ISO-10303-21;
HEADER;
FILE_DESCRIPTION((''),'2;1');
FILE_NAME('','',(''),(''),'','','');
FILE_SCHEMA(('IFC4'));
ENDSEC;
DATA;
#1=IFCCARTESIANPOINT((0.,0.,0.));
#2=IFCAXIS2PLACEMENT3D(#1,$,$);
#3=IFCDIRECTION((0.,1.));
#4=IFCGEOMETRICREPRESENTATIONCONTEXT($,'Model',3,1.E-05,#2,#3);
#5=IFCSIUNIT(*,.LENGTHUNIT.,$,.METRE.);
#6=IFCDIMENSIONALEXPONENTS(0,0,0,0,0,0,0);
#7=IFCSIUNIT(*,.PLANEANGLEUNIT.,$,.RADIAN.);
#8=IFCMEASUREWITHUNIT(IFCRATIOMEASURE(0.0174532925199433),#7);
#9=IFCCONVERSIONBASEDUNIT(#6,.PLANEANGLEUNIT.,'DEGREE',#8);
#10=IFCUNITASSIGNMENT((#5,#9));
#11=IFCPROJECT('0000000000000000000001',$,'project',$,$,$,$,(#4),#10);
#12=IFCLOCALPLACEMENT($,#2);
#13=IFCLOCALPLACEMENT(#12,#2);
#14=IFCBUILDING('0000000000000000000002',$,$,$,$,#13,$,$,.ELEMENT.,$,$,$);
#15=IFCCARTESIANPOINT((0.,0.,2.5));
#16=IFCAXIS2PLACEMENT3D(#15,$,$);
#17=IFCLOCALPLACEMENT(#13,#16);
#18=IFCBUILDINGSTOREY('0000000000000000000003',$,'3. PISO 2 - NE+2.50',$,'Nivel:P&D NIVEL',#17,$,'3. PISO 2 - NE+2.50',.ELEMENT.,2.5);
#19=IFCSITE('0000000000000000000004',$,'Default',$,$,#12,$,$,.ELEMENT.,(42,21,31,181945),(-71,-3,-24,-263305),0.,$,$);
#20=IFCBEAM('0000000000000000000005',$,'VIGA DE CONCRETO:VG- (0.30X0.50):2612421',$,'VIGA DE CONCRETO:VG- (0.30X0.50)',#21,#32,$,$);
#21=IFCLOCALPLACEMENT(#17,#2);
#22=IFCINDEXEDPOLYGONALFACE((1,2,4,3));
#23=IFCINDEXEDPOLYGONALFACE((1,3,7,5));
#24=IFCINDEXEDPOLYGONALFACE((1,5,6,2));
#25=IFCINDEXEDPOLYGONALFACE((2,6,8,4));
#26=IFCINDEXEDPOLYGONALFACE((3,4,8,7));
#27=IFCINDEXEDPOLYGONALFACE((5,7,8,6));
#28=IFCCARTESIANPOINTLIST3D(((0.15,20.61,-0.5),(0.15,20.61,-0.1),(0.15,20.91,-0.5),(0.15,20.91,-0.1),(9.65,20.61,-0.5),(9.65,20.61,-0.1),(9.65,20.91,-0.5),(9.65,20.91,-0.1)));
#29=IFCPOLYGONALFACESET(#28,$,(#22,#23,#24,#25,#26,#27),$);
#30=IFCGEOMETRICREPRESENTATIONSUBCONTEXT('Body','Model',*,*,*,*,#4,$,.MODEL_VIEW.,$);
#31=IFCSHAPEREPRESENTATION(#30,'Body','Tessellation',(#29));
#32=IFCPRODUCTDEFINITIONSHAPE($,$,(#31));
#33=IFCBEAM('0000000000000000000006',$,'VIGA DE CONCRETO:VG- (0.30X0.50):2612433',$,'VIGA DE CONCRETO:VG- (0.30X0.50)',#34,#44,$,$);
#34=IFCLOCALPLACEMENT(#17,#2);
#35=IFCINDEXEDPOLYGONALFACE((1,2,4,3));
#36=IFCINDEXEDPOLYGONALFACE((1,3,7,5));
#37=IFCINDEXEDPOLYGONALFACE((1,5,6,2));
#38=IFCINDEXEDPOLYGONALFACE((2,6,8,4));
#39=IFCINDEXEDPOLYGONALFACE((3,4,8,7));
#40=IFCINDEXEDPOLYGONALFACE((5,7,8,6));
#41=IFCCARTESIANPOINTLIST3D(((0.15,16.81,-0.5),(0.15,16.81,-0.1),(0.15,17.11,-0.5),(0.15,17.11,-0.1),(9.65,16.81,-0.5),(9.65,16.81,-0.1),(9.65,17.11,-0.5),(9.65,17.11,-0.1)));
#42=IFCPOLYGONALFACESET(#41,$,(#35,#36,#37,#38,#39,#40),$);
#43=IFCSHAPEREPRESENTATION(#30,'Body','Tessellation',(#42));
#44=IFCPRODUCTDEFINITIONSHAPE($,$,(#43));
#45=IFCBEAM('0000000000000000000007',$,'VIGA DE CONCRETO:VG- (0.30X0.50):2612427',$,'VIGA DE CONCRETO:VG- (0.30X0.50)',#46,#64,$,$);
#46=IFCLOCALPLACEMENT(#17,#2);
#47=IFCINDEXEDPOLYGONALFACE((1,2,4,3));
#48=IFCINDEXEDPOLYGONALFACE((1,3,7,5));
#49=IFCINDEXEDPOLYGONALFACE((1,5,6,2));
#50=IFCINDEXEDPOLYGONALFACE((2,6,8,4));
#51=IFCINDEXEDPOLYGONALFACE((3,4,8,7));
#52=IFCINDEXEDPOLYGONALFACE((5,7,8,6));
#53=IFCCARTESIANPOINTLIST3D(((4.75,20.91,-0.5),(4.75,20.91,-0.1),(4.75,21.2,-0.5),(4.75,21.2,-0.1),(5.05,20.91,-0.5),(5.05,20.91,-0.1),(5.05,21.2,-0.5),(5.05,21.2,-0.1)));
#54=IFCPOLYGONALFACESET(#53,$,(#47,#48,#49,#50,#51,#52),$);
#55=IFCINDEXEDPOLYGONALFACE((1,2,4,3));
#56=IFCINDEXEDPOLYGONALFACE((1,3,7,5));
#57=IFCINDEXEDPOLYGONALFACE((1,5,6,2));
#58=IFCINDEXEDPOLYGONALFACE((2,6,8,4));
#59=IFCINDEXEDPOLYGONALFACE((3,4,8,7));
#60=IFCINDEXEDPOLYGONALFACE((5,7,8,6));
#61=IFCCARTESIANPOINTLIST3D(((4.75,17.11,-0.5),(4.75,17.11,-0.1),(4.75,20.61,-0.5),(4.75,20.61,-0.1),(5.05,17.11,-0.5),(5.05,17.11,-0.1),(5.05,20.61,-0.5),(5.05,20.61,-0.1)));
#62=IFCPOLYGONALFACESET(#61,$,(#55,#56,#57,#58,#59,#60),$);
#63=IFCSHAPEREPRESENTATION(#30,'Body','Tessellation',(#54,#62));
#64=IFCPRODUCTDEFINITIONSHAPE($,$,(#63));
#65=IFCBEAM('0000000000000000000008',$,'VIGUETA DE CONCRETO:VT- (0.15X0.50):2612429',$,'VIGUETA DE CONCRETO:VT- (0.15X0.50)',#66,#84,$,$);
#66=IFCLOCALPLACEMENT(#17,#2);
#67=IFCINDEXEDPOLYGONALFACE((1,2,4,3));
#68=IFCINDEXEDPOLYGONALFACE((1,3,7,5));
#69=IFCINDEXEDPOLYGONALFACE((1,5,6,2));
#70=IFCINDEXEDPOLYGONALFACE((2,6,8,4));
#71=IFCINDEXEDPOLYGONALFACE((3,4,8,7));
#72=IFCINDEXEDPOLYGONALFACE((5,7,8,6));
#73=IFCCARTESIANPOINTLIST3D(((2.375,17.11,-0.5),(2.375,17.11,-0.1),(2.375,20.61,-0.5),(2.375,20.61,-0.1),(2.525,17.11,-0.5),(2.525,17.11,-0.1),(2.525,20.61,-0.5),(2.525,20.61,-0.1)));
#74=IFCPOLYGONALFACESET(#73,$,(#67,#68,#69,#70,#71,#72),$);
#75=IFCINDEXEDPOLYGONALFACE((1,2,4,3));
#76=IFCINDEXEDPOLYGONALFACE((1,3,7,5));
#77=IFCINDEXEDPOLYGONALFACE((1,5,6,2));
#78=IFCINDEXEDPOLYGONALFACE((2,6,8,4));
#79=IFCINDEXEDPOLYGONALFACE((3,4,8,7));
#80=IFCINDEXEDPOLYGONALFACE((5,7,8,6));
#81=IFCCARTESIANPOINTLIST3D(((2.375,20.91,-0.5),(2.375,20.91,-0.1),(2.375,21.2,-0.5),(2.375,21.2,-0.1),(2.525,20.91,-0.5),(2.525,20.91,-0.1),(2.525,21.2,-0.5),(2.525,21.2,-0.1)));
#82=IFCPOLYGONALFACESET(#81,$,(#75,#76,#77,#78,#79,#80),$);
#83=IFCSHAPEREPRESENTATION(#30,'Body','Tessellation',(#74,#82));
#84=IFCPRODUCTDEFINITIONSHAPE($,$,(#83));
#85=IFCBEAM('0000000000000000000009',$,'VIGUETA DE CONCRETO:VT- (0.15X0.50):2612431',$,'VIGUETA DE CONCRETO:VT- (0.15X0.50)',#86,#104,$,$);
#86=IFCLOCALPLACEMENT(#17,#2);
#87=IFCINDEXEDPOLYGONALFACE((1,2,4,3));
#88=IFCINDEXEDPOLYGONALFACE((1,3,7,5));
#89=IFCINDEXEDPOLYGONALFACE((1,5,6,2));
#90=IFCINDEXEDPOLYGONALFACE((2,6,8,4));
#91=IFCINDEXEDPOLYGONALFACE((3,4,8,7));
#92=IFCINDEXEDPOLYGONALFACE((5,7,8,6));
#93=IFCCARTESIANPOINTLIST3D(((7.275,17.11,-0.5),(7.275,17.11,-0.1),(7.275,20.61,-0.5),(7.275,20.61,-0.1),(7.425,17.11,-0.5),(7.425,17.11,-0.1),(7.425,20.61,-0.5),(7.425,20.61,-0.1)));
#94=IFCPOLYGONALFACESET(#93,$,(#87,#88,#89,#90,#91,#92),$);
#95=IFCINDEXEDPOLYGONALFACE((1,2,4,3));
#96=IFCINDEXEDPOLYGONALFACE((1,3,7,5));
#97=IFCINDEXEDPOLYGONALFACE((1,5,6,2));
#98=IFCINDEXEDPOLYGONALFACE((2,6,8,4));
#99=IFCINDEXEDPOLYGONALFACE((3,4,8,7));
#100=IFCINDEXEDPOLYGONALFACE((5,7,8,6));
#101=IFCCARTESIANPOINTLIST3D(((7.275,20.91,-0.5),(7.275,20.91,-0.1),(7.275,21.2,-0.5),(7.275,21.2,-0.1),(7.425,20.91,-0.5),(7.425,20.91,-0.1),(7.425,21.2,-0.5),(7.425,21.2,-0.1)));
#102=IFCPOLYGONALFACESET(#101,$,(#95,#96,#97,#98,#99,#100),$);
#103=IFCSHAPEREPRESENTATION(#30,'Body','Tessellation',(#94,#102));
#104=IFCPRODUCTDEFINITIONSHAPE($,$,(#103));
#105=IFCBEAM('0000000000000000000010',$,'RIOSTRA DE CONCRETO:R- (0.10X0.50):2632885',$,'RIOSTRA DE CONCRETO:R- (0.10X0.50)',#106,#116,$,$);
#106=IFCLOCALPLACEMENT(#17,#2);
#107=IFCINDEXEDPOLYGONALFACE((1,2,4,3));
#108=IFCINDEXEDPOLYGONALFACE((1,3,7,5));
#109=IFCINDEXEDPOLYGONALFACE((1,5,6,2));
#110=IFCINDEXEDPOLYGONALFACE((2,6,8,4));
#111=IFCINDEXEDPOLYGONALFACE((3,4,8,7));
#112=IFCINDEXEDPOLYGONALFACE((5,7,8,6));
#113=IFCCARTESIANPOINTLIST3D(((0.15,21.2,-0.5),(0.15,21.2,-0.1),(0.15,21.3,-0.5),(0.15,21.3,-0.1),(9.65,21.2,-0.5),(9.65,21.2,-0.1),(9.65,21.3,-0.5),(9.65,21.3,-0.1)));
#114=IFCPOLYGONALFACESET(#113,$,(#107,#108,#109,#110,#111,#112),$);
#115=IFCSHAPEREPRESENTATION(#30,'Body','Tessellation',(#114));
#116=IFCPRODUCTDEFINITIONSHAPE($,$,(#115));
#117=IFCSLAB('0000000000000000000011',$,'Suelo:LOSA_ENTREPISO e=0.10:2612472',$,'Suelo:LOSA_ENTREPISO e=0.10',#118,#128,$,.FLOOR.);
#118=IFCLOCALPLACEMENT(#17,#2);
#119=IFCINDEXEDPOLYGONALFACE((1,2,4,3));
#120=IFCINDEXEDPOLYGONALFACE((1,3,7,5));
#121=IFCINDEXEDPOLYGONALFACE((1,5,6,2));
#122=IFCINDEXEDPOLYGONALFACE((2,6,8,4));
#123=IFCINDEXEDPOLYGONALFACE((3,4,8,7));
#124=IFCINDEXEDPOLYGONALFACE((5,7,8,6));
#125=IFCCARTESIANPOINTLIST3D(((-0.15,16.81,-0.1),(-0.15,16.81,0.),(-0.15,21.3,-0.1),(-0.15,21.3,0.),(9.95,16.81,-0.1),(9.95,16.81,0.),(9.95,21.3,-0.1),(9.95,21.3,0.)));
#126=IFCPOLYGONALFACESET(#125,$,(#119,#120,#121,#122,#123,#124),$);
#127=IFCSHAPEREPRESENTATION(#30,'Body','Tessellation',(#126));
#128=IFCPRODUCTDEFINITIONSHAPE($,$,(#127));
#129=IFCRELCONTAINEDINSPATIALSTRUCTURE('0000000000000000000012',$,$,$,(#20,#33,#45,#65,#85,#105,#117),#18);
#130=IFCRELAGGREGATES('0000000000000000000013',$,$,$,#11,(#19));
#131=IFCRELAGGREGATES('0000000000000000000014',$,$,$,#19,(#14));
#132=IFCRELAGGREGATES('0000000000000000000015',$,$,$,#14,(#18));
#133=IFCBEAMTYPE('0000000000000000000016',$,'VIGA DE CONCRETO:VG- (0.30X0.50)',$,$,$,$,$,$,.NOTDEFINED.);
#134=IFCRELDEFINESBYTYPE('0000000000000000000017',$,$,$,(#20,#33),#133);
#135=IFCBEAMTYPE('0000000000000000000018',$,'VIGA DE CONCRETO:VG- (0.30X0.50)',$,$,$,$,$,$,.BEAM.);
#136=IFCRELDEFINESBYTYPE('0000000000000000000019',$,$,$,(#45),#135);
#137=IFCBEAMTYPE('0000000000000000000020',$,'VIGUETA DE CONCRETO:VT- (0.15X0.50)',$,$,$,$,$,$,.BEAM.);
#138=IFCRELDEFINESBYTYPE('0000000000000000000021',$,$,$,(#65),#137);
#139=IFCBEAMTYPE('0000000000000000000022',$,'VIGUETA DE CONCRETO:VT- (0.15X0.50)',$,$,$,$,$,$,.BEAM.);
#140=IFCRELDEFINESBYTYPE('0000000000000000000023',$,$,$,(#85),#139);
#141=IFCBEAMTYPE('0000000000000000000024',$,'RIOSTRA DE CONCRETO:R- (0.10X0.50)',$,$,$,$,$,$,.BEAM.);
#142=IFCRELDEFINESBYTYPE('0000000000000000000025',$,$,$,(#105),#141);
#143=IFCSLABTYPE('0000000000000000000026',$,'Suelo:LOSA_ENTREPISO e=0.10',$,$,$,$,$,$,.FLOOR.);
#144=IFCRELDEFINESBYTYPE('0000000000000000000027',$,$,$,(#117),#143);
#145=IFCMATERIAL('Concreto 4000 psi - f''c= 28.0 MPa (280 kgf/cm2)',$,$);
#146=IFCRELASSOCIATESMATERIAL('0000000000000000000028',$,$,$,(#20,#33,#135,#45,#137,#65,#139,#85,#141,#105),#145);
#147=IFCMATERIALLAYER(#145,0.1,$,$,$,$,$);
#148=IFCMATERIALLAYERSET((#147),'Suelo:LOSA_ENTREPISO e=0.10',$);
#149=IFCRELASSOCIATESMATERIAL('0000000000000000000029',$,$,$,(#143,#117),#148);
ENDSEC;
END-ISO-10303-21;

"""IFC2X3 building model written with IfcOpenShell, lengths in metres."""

from ifc_helpers import new_model, entity, si_unit, converted_unit, direction, frame, frame_2d, origin, origin_2d_with_axis, place, context, subcontext, project, spatial, rectangle, extrude, source, transform, mapped, material, layer, layer_set, layer_usage, type_object, type_shapes, element, save


model = new_model("IFC2X3")

# Units and contexts
model_context = context("Model", 3, precision=1e-05, world=origin(), true_north=direction((0.0, 1.0)))
body_context = subcontext(model_context, "Body", "Model", "MODEL_VIEW")
ifc_project = project(units=[si_unit("LENGTHUNIT", "METRE"), converted_unit("PLANEANGLEUNIT", "DEGREE", entity("IfcRatioMeasure", 0.0174532925199433), si_unit("PLANEANGLEUNIT", "RADIAN"), dimensions=[0, 0, 0, 0, 0, 0, 0])], contexts=[model_context])

# Site, building, storey
site_placement = place(None, origin())
site = spatial("IfcSite", under=ifc_project, at=site_placement, Name="Default", CompositionType="ELEMENT", RefLatitude=(42, 21, 31, 181945), RefLongitude=(-71, -3, -24, -263305), RefElevation=0.0)
building_placement = place(site_placement, origin())
building = spatial("IfcBuilding", under=site, at=building_placement, CompositionType="ELEMENT")
storey_placement = place(building_placement, frame((0.0, 0.0, 2.5)))
storey = spatial("IfcBuildingStorey", under=building, at=storey_placement, Name="3. PISO 2 - NE+2.50", ObjectType="Nivel:P&D NIVEL", LongName="3. PISO 2 - NE+2.50", CompositionType="ELEMENT", Elevation=2.5)

# Beams
ifc_material = material(Name="Concreto 4000 psi - f'c= 28.0 MPa (280 kgf/cm2)")
beam_type_1 = type_object("IfcBeamType", Name="VIGA DE CONCRETO:VG- (0.30X0.50)", PredefinedType="NOTDEFINED")
beam_1_placement = place(storey_placement, frame((9.8, 20.76, 0.0), z_axis=(0.0, 0.0, 1.0), x_axis=(-1.0, 0.0, 0.0)))
element("IfcBeam", 1, at=beam_1_placement, inside=storey, type_object=beam_type_1, material=ifc_material, Name="VIGA DE CONCRETO:VG- (0.30X0.50):2612421", ObjectType="VIGA DE CONCRETO:VG- (0.30X0.50)", context=body_context, shape_type="SweptSolid", body=[
    extrude(rectangle(XDim=0.4, YDim=0.3, at=frame_2d((0.0, 0.0), x_axis=(1.0, 0.0))), frame((0.15, 0.0, -0.3), z_axis=(1.0, 0.0, 0.0), x_axis=(0.0, 0.0, -1.0)), (0.0, 0.0, 1.0), 9.5),
])
beam_2_placement = place(storey_placement, frame((0.0, 16.96, 0.0)))
element("IfcBeam", 2, at=beam_2_placement, inside=storey, type_object=beam_type_1, material=ifc_material, Name="VIGA DE CONCRETO:VG- (0.30X0.50):2612433", ObjectType="VIGA DE CONCRETO:VG- (0.30X0.50)", context=body_context, shape_type="SweptSolid", body=[
    extrude(rectangle(XDim=0.4, YDim=0.3, at=frame_2d((0.0, 0.0), x_axis=(1.0, 0.0))), frame((0.15, 0.0, -0.3), z_axis=(1.0, 0.0, 0.0), x_axis=(0.0, 0.0, -1.0)), (0.0, 0.0, 1.0), 9.5),
])
beam_type_2 = type_object("IfcBeamType", Name="VIGA DE CONCRETO:VG- (0.30X0.50)", PredefinedType="BEAM", material=ifc_material)
shared_shape_1 = source(origin(), body_context, "Body", "SweptSolid", [
    extrude(rectangle(XDim=0.4, YDim=0.3, at=frame_2d((0.0, 0.0), x_axis=(0.0, 1.0))), frame((4.9, 21.2, 2.2), z_axis=(0.0, -1.0, 0.0), x_axis=(-1.0, 0.0, 0.0)), (0.0, 0.0, 1.0), 0.29),
    extrude(rectangle(XDim=0.4, YDim=0.3, at=frame_2d((0.0, 0.0), x_axis=(0.0, 1.0))), frame((4.9, 20.61, 2.2), z_axis=(0.0, -1.0, 0.0), x_axis=(-1.0, 0.0, 0.0)), (0.0, 0.0, 1.0), 3.5),
])
type_shapes(beam_type_2, [shared_shape_1])
beam_3_placement = place(storey_placement, frame((0.0, 0.0, -2.5)))
element("IfcBeam", 3, at=beam_3_placement, inside=storey, type_object=beam_type_2, material=ifc_material, Name="VIGA DE CONCRETO:VG- (0.30X0.50):2612427", ObjectType="VIGA DE CONCRETO:VG- (0.30X0.50)", context=body_context, shape_type="MappedRepresentation", body=[
    mapped(shared_shape_1, transform((0.0, 0.0, 0.0), scale=1.0)),
])
beam_type_3 = type_object("IfcBeamType", Name="VIGUETA DE CONCRETO:VT- (0.15X0.50)", PredefinedType="BEAM", material=ifc_material)
shared_shape_2 = source(origin(), body_context, "Body", "SweptSolid", [
    extrude(rectangle(XDim=0.4, YDim=0.15, at=frame_2d((0.0, 0.0), x_axis=(0.0, 1.0))), frame((2.45, 20.61, 2.2), z_axis=(0.0, -1.0, 0.0), x_axis=(-1.0, 0.0, 0.0)), (0.0, 0.0, 1.0), 3.5),
    extrude(rectangle(XDim=0.4, YDim=0.15, at=frame_2d((0.0, 0.0), x_axis=(0.0, 1.0))), frame((2.45, 21.2, 2.2), z_axis=(0.0, -1.0, 0.0), x_axis=(-1.0, 0.0, 0.0)), (0.0, 0.0, 1.0), 0.29),
])
type_shapes(beam_type_3, [shared_shape_2])
beam_4_placement = place(storey_placement, frame((0.0, 0.0, -2.5)))
element("IfcBeam", 4, at=beam_4_placement, inside=storey, type_object=beam_type_3, material=ifc_material, Name="VIGUETA DE CONCRETO:VT- (0.15X0.50):2612429", ObjectType="VIGUETA DE CONCRETO:VT- (0.15X0.50)", context=body_context, shape_type="MappedRepresentation", body=[
    mapped(shared_shape_2, transform((0.0, 0.0, 0.0), scale=1.0)),
])
beam_type_4 = type_object("IfcBeamType", Name="VIGUETA DE CONCRETO:VT- (0.15X0.50)", PredefinedType="BEAM", material=ifc_material)
shared_shape_3 = source(origin(), body_context, "Body", "SweptSolid", [
    extrude(rectangle(XDim=0.4, YDim=0.15, at=frame_2d((0.0, 0.0), x_axis=(0.0, 1.0))), frame((7.35, 20.61, 2.2), z_axis=(0.0, -1.0, 0.0), x_axis=(-1.0, 0.0, 0.0)), (0.0, 0.0, 1.0), 3.5),
    extrude(rectangle(XDim=0.4, YDim=0.15, at=frame_2d((0.0, 0.0), x_axis=(0.0, 1.0))), frame((7.35, 21.2, 2.2), z_axis=(0.0, -1.0, 0.0), x_axis=(-1.0, 0.0, 0.0)), (0.0, 0.0, 1.0), 0.29),
])
type_shapes(beam_type_4, [shared_shape_3])
beam_5_placement = place(storey_placement, frame((0.0, 0.0, -2.5)))
element("IfcBeam", 5, at=beam_5_placement, inside=storey, type_object=beam_type_4, material=ifc_material, Name="VIGUETA DE CONCRETO:VT- (0.15X0.50):2612431", ObjectType="VIGUETA DE CONCRETO:VT- (0.15X0.50)", context=body_context, shape_type="MappedRepresentation", body=[
    mapped(shared_shape_3, transform((0.0, 0.0, 0.0), scale=1.0)),
])
beam_type_5 = type_object("IfcBeamType", Name="RIOSTRA DE CONCRETO:R- (0.10X0.50)", PredefinedType="BEAM", material=ifc_material)
beam_6_placement = place(storey_placement, frame((0.0, 21.25, 0.0)))
element("IfcBeam", 6, at=beam_6_placement, inside=storey, type_object=beam_type_5, material=ifc_material, Name="RIOSTRA DE CONCRETO:R- (0.10X0.50):2632885", ObjectType="RIOSTRA DE CONCRETO:R- (0.10X0.50)", context=body_context, shape_type="SweptSolid", body=[
    extrude(rectangle(XDim=0.4, YDim=0.1, at=frame_2d((0.0, 0.0), x_axis=(1.0, 0.0))), frame((0.15, 0.0, -0.3), z_axis=(1.0, 0.0, 0.0), x_axis=(0.0, 0.0, -1.0)), (0.0, 0.0, 1.0), 9.5),
])

# Slab
ifc_layer = layer(ifc_material, 0.1)
ifc_layer_set = layer_set([ifc_layer], Name="Suelo:LOSA_ENTREPISO e=0.10")
ifc_layer_usage = layer_usage(ifc_layer_set, "AXIS3", "POSITIVE", 0.0)
slab_type = type_object("IfcSlabType", Name="Suelo:LOSA_ENTREPISO e=0.10", PredefinedType="FLOOR", material=ifc_layer_set)
slab_placement = place(storey_placement, origin())
element("IfcSlab", 7, at=slab_placement, inside=storey, type_object=slab_type, material=ifc_layer_usage, Name="Suelo:LOSA_ENTREPISO e=0.10:2612472", ObjectType="Suelo:LOSA_ENTREPISO e=0.10", PredefinedType="FLOOR", context=body_context, shape_type="SweptSolid", body=[
    extrude(rectangle(XDim=4.49, YDim=10.1, at=origin_2d_with_axis()), frame((4.9, 19.055, 0.0), z_axis=(0.0, 0.0, -1.0), x_axis=(0.0, 1.0, 0.0)), (0.0, 0.0, 1.0), 0.1),
])

save(model, "model.ifc")
